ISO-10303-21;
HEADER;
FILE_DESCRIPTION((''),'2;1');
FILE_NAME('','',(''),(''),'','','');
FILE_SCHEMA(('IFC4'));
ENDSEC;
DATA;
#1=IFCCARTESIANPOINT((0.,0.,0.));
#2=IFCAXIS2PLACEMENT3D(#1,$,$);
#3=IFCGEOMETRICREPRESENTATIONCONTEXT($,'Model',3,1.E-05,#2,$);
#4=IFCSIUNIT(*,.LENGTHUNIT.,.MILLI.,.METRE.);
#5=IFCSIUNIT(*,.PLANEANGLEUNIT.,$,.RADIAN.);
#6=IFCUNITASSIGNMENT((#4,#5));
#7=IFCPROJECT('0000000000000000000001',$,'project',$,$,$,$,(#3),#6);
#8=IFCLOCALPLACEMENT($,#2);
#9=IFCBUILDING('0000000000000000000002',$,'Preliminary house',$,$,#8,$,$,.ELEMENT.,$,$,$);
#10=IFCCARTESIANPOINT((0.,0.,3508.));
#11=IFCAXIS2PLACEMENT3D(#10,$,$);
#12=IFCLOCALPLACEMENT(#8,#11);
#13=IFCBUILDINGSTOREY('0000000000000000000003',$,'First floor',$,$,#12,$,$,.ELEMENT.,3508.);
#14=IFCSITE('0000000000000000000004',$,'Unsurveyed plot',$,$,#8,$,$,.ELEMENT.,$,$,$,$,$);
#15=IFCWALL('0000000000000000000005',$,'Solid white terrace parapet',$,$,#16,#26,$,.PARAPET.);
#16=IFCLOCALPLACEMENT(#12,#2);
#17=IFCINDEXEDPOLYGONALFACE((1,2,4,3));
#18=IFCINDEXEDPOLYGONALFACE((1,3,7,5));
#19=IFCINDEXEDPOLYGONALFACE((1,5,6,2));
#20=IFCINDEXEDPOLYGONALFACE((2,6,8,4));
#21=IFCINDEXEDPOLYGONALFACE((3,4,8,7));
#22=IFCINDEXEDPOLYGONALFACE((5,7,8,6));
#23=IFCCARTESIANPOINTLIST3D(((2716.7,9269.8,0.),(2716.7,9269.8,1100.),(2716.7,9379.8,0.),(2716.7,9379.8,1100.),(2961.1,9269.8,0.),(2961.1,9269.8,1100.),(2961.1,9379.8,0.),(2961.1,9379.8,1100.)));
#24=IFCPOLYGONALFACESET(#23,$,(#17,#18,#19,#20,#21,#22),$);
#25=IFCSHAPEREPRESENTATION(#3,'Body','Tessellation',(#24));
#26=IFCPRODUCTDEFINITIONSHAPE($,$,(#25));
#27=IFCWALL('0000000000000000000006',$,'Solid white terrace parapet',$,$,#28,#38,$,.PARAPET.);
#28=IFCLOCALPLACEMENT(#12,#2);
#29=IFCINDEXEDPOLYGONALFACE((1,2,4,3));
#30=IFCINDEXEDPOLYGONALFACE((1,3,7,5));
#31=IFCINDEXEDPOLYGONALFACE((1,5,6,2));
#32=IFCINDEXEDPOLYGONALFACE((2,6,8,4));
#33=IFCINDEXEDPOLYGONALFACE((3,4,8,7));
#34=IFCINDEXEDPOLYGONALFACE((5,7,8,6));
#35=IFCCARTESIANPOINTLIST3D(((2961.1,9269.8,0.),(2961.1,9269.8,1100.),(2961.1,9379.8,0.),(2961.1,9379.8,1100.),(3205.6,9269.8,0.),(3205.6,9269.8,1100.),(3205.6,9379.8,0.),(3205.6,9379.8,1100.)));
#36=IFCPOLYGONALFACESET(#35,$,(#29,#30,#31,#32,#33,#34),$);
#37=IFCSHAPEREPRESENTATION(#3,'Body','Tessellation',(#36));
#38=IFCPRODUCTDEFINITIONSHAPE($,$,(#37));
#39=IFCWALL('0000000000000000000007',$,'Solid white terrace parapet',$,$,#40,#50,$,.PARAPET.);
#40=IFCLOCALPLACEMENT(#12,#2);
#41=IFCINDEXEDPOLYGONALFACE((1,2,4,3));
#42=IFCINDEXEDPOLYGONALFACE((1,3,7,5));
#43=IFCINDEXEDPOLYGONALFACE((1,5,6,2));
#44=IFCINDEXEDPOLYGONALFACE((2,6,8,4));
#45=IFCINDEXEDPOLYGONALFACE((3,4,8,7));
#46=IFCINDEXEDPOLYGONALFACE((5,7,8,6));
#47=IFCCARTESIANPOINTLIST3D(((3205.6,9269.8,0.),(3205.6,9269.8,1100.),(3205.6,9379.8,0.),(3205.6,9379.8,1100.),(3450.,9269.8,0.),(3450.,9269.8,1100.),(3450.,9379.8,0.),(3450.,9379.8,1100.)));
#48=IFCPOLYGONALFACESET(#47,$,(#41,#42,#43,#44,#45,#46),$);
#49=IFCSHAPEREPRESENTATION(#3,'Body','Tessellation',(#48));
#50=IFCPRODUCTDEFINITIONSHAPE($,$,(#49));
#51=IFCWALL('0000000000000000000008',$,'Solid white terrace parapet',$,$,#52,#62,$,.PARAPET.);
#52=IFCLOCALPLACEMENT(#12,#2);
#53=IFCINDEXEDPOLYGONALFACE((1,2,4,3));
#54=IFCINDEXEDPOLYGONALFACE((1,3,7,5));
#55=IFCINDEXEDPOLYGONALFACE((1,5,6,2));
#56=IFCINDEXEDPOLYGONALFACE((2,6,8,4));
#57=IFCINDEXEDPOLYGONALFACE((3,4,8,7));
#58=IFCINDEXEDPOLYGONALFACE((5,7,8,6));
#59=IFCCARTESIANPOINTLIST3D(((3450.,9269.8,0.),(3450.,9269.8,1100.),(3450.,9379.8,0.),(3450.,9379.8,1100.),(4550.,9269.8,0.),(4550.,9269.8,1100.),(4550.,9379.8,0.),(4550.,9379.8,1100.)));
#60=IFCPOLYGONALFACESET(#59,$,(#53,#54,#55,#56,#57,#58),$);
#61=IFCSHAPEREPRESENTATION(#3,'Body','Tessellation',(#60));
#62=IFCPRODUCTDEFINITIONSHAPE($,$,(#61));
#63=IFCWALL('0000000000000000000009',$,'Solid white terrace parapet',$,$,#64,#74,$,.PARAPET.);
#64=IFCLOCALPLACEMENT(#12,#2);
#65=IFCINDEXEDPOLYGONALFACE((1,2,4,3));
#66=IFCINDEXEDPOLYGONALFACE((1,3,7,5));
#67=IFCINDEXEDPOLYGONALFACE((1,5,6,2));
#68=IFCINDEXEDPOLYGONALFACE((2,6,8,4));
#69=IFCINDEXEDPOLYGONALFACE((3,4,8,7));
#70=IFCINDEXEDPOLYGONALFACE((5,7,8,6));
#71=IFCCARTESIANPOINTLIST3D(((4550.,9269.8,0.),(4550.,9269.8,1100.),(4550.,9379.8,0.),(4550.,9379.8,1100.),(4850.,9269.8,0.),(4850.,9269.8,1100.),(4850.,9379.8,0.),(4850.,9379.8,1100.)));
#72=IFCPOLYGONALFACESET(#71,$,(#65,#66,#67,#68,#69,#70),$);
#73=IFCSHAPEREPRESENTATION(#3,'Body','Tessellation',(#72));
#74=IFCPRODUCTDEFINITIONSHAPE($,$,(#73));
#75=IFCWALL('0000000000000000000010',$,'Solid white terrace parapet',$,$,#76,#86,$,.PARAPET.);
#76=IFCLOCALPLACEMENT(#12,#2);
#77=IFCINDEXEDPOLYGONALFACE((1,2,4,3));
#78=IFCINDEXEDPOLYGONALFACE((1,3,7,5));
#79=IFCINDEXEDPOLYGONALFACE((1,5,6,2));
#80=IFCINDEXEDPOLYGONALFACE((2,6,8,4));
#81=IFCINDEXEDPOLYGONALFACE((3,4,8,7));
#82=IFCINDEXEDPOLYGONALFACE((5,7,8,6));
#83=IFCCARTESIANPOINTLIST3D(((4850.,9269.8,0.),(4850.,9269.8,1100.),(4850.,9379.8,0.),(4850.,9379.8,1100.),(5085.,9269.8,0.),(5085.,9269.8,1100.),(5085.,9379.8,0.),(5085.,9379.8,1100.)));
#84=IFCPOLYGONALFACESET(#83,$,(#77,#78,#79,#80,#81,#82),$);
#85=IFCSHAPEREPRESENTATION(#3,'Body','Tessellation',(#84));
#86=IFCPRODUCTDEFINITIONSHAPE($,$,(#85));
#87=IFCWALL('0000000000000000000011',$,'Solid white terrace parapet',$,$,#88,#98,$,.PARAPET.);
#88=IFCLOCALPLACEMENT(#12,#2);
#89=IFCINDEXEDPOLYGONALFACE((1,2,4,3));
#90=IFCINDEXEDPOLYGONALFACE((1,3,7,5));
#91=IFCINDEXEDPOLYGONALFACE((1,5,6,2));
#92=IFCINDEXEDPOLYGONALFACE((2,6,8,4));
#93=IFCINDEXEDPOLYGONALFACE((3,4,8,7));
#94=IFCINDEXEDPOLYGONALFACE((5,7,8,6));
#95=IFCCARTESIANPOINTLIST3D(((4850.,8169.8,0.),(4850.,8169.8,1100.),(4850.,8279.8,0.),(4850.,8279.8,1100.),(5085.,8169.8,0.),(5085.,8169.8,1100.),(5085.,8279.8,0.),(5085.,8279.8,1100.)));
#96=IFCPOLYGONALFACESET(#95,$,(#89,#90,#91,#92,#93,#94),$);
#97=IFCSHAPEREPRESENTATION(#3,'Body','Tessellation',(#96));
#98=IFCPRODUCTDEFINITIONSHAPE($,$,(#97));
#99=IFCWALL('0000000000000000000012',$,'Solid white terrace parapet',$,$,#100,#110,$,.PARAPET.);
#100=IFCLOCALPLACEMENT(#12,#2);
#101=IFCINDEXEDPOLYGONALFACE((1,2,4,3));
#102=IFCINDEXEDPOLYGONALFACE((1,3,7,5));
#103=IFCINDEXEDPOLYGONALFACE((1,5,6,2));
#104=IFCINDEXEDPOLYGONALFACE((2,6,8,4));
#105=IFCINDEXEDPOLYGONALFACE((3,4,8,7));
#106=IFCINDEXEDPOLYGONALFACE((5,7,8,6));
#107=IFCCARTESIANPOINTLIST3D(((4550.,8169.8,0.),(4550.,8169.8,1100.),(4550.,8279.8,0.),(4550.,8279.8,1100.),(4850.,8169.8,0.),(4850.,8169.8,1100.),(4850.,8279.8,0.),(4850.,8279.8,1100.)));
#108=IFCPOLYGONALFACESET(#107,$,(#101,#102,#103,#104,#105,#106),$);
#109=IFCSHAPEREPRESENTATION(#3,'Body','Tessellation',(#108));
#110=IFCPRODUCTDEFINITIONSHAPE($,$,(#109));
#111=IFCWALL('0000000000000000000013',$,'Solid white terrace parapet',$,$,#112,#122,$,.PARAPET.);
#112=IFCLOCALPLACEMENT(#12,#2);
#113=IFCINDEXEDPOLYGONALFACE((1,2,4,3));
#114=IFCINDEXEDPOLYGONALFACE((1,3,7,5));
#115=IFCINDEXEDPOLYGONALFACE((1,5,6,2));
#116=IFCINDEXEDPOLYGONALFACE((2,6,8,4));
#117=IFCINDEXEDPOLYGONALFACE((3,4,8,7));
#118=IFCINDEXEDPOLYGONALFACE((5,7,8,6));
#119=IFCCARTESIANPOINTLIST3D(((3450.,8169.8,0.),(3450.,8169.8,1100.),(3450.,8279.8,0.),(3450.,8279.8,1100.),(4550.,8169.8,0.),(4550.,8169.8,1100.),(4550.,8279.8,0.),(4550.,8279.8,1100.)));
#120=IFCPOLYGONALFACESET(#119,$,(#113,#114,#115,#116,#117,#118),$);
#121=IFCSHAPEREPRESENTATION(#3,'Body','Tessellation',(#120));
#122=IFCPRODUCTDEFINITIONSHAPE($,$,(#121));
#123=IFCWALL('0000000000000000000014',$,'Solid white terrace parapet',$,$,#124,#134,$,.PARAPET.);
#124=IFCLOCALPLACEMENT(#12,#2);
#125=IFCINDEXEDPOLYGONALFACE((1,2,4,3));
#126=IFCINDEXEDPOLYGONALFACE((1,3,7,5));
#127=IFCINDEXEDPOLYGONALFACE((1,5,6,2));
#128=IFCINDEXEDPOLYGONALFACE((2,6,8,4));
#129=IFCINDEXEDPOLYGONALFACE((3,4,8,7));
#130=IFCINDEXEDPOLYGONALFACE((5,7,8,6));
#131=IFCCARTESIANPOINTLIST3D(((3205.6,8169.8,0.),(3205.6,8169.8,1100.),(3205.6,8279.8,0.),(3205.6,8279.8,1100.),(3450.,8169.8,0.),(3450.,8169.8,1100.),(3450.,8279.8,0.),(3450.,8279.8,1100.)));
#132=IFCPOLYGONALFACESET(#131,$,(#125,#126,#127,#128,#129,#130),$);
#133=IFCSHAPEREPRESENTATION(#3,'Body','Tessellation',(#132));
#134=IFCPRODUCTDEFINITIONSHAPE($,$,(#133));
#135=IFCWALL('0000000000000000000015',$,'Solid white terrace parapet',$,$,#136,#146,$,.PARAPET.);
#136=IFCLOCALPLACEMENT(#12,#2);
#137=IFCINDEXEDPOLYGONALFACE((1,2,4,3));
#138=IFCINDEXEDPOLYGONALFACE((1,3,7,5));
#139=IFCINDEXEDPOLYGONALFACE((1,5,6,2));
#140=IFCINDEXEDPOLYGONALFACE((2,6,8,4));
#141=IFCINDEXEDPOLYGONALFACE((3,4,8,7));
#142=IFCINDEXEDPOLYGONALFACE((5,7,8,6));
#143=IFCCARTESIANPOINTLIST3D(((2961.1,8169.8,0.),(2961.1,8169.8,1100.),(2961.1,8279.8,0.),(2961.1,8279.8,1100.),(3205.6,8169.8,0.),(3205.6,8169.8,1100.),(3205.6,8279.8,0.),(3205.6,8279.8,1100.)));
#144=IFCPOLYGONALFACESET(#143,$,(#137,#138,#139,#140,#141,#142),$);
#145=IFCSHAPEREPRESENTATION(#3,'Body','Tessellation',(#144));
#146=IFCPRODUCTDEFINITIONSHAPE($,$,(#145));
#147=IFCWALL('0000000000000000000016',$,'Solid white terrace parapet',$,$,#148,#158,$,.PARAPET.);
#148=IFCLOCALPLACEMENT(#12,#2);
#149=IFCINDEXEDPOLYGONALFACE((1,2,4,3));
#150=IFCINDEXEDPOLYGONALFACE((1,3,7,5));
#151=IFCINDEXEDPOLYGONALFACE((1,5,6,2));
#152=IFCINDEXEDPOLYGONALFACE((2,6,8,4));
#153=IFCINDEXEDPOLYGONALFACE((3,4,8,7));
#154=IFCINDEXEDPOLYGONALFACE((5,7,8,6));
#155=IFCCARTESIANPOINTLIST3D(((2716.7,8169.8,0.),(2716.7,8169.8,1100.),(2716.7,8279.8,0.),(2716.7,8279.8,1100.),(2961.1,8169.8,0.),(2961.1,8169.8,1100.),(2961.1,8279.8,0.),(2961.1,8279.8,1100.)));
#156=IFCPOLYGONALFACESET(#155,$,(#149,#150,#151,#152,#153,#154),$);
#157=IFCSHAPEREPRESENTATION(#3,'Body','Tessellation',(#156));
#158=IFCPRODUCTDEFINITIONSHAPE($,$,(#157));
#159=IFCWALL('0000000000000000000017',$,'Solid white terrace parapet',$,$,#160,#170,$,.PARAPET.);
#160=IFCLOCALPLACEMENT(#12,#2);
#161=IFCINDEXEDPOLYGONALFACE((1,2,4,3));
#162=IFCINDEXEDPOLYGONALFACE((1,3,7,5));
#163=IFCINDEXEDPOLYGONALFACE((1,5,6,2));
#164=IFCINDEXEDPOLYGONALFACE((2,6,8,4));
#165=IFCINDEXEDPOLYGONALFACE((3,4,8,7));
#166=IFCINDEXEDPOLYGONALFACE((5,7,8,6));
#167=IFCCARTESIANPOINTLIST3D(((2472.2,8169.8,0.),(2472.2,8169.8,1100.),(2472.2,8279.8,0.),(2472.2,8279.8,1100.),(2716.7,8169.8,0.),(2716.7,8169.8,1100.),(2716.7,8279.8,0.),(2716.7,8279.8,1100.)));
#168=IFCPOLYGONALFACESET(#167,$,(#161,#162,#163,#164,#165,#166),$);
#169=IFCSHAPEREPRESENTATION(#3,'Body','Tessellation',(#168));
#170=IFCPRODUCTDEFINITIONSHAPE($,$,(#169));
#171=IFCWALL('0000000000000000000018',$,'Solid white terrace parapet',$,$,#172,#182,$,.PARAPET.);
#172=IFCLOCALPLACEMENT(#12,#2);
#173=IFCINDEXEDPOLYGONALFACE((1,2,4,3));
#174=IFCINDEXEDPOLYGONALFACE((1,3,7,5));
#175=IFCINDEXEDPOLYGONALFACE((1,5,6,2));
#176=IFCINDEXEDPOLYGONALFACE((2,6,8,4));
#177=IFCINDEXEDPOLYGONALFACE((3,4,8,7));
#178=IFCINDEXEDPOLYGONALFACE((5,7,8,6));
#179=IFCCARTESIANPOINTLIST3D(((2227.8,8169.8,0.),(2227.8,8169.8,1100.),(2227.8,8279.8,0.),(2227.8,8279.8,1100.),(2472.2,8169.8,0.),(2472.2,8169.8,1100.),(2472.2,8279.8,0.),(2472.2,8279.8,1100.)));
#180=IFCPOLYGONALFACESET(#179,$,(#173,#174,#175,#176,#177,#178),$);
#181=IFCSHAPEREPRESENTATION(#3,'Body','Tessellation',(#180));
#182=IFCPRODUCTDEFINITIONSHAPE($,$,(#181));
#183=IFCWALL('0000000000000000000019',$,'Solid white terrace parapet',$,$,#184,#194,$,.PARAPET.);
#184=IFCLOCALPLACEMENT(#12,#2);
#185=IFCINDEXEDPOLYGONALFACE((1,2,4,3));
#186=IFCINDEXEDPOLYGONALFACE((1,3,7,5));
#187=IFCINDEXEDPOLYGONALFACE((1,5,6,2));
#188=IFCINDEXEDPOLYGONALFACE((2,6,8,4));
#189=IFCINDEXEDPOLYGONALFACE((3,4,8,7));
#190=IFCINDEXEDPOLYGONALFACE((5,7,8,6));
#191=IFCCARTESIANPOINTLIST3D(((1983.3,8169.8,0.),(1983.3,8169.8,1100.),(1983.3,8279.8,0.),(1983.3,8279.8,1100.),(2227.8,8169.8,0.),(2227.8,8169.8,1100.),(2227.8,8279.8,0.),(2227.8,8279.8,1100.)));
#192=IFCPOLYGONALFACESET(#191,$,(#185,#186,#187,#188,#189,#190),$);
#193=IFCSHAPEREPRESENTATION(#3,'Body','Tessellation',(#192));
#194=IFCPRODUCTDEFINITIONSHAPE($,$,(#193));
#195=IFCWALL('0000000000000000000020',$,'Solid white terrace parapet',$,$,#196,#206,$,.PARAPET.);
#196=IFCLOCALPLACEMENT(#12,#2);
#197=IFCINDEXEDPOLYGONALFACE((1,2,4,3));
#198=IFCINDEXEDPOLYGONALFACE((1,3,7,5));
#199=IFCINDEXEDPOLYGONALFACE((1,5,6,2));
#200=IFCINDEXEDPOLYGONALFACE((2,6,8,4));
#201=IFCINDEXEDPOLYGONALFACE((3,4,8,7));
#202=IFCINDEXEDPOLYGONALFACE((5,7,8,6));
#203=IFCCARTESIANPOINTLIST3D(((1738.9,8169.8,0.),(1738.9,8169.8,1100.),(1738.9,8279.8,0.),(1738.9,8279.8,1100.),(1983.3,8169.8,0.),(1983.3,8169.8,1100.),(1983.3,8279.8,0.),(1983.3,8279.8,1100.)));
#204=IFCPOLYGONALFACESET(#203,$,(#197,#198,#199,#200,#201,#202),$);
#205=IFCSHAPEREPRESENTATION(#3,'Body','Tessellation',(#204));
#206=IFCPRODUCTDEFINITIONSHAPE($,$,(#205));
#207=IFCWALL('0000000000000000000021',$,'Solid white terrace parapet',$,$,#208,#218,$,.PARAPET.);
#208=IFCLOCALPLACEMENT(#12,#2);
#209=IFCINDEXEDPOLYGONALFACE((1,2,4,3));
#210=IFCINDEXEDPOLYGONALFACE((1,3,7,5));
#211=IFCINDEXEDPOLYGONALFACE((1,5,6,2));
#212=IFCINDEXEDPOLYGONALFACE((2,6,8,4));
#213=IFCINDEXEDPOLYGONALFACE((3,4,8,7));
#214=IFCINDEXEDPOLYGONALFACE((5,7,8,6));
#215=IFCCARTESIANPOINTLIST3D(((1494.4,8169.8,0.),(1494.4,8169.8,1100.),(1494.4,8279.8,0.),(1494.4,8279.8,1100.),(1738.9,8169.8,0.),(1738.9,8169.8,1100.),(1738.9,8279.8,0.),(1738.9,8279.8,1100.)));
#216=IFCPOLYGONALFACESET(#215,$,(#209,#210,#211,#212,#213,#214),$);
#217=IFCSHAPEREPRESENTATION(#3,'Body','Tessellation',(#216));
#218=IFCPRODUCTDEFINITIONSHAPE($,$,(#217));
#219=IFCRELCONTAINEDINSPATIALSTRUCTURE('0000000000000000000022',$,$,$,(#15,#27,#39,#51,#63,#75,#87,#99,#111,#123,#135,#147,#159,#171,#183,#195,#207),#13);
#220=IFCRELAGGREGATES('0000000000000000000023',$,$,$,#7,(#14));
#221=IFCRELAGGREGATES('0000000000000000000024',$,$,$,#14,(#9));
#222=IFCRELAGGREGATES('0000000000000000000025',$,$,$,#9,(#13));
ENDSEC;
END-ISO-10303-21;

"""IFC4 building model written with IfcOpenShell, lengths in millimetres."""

from ifc_helpers import new_model, si_unit, frame, origin, place, context, project, spatial, polyline, outline, extrude, element, save


model = new_model("IFC4")

# Units and contexts
model_context = context("Model", 3, precision=1e-05, world=origin())
ifc_project = project(units=[si_unit("LENGTHUNIT", "METRE", prefix="MILLI"), si_unit("PLANEANGLEUNIT", "RADIAN")], contexts=[model_context])

# Site, building, storey
placement_1 = place(None, origin())
site = spatial("IfcSite", under=ifc_project, at=placement_1, Name="Unsurveyed plot", CompositionType="ELEMENT")
building = spatial("IfcBuilding", under=site, at=placement_1, Name="Preliminary house", CompositionType="ELEMENT")
placement_2 = place(placement_1, frame((0.0, 0.0, 3508.0)))
storey = spatial("IfcBuildingStorey", under=building, at=placement_2, Name="First floor", CompositionType="ELEMENT", Elevation=3508.0)

# Walls
element("IfcWall", 1, at=placement_2, inside=storey, Name="Solid white terrace parapet", PredefinedType="PARAPET", context=model_context, shape_type="SweptSolid", body=[
    extrude(outline(polyline([(2961.1, 9379.8), (2961.1, 9269.8), (2716.7, 9269.8), (2716.7, 9379.8), (2961.1, 9379.8)])), origin(), (0.0, 0.0, 1.0), 1100.0),
])
element("IfcWall", 2, at=placement_2, inside=storey, Name="Solid white terrace parapet", PredefinedType="PARAPET", context=model_context, shape_type="SweptSolid", body=[
    extrude(outline(polyline([(3205.6, 9379.8), (3205.6, 9269.8), (2961.1, 9269.8), (2961.1, 9379.8), (3205.6, 9379.8)])), origin(), (0.0, 0.0, 1.0), 1100.0),
])
element("IfcWall", 3, at=placement_2, inside=storey, Name="Solid white terrace parapet", PredefinedType="PARAPET", context=model_context, shape_type="SweptSolid", body=[
    extrude(outline(polyline([(3450.0, 9379.8), (3450.0, 9269.8), (3205.6, 9269.8), (3205.6, 9379.8), (3450.0, 9379.8)])), origin(), (0.0, 0.0, 1.0), 1100.0),
])
element("IfcWall", 4, at=placement_2, inside=storey, Name="Solid white terrace parapet", PredefinedType="PARAPET", context=model_context, shape_type="SweptSolid", body=[
    extrude(outline(polyline([(4550.0, 9379.8), (4550.0, 9269.8), (3450.0, 9269.8), (3450.0, 9379.8), (4550.0, 9379.8)])), origin(), (0.0, 0.0, 1.0), 1100.0),
])
element("IfcWall", 5, at=placement_2, inside=storey, Name="Solid white terrace parapet", PredefinedType="PARAPET", context=model_context, shape_type="SweptSolid", body=[
    extrude(outline(polyline([(4850.0, 9379.8), (4850.0, 9269.8), (4550.0, 9269.8), (4550.0, 9379.8), (4850.0, 9379.8)])), origin(), (0.0, 0.0, 1.0), 1100.0),
])
element("IfcWall", 6, at=placement_2, inside=storey, Name="Solid white terrace parapet", PredefinedType="PARAPET", context=model_context, shape_type="SweptSolid", body=[
    extrude(outline(polyline([(5085.0, 9379.8), (5085.0, 9269.8), (4850.0, 9269.8), (4850.0, 9379.8), (5085.0, 9379.8)])), origin(), (0.0, 0.0, 1.0), 1100.0),
])
element("IfcWall", 7, at=placement_2, inside=storey, Name="Solid white terrace parapet", PredefinedType="PARAPET", context=model_context, shape_type="SweptSolid", body=[
    extrude(outline(polyline([(4850.0, 8169.8), (4850.0, 8279.8), (5085.0, 8279.8), (5085.0, 8169.8), (4850.0, 8169.8)])), origin(), (0.0, 0.0, 1.0), 1100.0),
])
element("IfcWall", 8, at=placement_2, inside=storey, Name="Solid white terrace parapet", PredefinedType="PARAPET", context=model_context, shape_type="SweptSolid", body=[
    extrude(outline(polyline([(4550.0, 8169.8), (4550.0, 8279.8), (4850.0, 8279.8), (4850.0, 8169.8), (4550.0, 8169.8)])), origin(), (0.0, 0.0, 1.0), 1100.0),
])
element("IfcWall", 9, at=placement_2, inside=storey, Name="Solid white terrace parapet", PredefinedType="PARAPET", context=model_context, shape_type="SweptSolid", body=[
    extrude(outline(polyline([(3450.0, 8169.8), (3450.0, 8279.8), (4550.0, 8279.8), (4550.0, 8169.8), (3450.0, 8169.8)])), origin(), (0.0, 0.0, 1.0), 1100.0),
])
element("IfcWall", 10, at=placement_2, inside=storey, Name="Solid white terrace parapet", PredefinedType="PARAPET", context=model_context, shape_type="SweptSolid", body=[
    extrude(outline(polyline([(3205.6, 8169.8), (3205.6, 8279.8), (3450.0, 8279.8), (3450.0, 8169.8), (3205.6, 8169.8)])), origin(), (0.0, 0.0, 1.0), 1100.0),
])
element("IfcWall", 11, at=placement_2, inside=storey, Name="Solid white terrace parapet", PredefinedType="PARAPET", context=model_context, shape_type="SweptSolid", body=[
    extrude(outline(polyline([(2961.1, 8169.8), (2961.1, 8279.8), (3205.6, 8279.8), (3205.6, 8169.8), (2961.1, 8169.8)])), origin(), (0.0, 0.0, 1.0), 1100.0),
])
element("IfcWall", 12, at=placement_2, inside=storey, Name="Solid white terrace parapet", PredefinedType="PARAPET", context=model_context, shape_type="SweptSolid", body=[
    extrude(outline(polyline([(2716.7, 8169.8), (2716.7, 8279.8), (2961.1, 8279.8), (2961.1, 8169.8), (2716.7, 8169.8)])), origin(), (0.0, 0.0, 1.0), 1100.0),
])
element("IfcWall", 13, at=placement_2, inside=storey, Name="Solid white terrace parapet", PredefinedType="PARAPET", context=model_context, shape_type="SweptSolid", body=[
    extrude(outline(polyline([(2472.2, 8169.8), (2472.2, 8279.8), (2716.7, 8279.8), (2716.7, 8169.8), (2472.2, 8169.8)])), origin(), (0.0, 0.0, 1.0), 1100.0),
])
element("IfcWall", 14, at=placement_2, inside=storey, Name="Solid white terrace parapet", PredefinedType="PARAPET", context=model_context, shape_type="SweptSolid", body=[
    extrude(outline(polyline([(2227.8, 8169.8), (2227.8, 8279.8), (2472.2, 8279.8), (2472.2, 8169.8), (2227.8, 8169.8)])), origin(), (0.0, 0.0, 1.0), 1100.0),
])
element("IfcWall", 15, at=placement_2, inside=storey, Name="Solid white terrace parapet", PredefinedType="PARAPET", context=model_context, shape_type="SweptSolid", body=[
    extrude(outline(polyline([(1983.3, 8169.8), (1983.3, 8279.8), (2227.8, 8279.8), (2227.8, 8169.8), (1983.3, 8169.8)])), origin(), (0.0, 0.0, 1.0), 1100.0),
])
element("IfcWall", 16, at=placement_2, inside=storey, Name="Solid white terrace parapet", PredefinedType="PARAPET", context=model_context, shape_type="SweptSolid", body=[
    extrude(outline(polyline([(1738.9, 8169.8), (1738.9, 8279.8), (1983.3, 8279.8), (1983.3, 8169.8), (1738.9, 8169.8)])), origin(), (0.0, 0.0, 1.0), 1100.0),
])
element("IfcWall", 17, at=placement_2, inside=storey, Name="Solid white terrace parapet", PredefinedType="PARAPET", context=model_context, shape_type="SweptSolid", body=[
    extrude(outline(polyline([(1494.4, 8169.8), (1494.4, 8279.8), (1738.9, 8279.8), (1738.9, 8169.8), (1494.4, 8169.8)])), origin(), (0.0, 0.0, 1.0), 1100.0),
])

save(model, "model.ifc")
